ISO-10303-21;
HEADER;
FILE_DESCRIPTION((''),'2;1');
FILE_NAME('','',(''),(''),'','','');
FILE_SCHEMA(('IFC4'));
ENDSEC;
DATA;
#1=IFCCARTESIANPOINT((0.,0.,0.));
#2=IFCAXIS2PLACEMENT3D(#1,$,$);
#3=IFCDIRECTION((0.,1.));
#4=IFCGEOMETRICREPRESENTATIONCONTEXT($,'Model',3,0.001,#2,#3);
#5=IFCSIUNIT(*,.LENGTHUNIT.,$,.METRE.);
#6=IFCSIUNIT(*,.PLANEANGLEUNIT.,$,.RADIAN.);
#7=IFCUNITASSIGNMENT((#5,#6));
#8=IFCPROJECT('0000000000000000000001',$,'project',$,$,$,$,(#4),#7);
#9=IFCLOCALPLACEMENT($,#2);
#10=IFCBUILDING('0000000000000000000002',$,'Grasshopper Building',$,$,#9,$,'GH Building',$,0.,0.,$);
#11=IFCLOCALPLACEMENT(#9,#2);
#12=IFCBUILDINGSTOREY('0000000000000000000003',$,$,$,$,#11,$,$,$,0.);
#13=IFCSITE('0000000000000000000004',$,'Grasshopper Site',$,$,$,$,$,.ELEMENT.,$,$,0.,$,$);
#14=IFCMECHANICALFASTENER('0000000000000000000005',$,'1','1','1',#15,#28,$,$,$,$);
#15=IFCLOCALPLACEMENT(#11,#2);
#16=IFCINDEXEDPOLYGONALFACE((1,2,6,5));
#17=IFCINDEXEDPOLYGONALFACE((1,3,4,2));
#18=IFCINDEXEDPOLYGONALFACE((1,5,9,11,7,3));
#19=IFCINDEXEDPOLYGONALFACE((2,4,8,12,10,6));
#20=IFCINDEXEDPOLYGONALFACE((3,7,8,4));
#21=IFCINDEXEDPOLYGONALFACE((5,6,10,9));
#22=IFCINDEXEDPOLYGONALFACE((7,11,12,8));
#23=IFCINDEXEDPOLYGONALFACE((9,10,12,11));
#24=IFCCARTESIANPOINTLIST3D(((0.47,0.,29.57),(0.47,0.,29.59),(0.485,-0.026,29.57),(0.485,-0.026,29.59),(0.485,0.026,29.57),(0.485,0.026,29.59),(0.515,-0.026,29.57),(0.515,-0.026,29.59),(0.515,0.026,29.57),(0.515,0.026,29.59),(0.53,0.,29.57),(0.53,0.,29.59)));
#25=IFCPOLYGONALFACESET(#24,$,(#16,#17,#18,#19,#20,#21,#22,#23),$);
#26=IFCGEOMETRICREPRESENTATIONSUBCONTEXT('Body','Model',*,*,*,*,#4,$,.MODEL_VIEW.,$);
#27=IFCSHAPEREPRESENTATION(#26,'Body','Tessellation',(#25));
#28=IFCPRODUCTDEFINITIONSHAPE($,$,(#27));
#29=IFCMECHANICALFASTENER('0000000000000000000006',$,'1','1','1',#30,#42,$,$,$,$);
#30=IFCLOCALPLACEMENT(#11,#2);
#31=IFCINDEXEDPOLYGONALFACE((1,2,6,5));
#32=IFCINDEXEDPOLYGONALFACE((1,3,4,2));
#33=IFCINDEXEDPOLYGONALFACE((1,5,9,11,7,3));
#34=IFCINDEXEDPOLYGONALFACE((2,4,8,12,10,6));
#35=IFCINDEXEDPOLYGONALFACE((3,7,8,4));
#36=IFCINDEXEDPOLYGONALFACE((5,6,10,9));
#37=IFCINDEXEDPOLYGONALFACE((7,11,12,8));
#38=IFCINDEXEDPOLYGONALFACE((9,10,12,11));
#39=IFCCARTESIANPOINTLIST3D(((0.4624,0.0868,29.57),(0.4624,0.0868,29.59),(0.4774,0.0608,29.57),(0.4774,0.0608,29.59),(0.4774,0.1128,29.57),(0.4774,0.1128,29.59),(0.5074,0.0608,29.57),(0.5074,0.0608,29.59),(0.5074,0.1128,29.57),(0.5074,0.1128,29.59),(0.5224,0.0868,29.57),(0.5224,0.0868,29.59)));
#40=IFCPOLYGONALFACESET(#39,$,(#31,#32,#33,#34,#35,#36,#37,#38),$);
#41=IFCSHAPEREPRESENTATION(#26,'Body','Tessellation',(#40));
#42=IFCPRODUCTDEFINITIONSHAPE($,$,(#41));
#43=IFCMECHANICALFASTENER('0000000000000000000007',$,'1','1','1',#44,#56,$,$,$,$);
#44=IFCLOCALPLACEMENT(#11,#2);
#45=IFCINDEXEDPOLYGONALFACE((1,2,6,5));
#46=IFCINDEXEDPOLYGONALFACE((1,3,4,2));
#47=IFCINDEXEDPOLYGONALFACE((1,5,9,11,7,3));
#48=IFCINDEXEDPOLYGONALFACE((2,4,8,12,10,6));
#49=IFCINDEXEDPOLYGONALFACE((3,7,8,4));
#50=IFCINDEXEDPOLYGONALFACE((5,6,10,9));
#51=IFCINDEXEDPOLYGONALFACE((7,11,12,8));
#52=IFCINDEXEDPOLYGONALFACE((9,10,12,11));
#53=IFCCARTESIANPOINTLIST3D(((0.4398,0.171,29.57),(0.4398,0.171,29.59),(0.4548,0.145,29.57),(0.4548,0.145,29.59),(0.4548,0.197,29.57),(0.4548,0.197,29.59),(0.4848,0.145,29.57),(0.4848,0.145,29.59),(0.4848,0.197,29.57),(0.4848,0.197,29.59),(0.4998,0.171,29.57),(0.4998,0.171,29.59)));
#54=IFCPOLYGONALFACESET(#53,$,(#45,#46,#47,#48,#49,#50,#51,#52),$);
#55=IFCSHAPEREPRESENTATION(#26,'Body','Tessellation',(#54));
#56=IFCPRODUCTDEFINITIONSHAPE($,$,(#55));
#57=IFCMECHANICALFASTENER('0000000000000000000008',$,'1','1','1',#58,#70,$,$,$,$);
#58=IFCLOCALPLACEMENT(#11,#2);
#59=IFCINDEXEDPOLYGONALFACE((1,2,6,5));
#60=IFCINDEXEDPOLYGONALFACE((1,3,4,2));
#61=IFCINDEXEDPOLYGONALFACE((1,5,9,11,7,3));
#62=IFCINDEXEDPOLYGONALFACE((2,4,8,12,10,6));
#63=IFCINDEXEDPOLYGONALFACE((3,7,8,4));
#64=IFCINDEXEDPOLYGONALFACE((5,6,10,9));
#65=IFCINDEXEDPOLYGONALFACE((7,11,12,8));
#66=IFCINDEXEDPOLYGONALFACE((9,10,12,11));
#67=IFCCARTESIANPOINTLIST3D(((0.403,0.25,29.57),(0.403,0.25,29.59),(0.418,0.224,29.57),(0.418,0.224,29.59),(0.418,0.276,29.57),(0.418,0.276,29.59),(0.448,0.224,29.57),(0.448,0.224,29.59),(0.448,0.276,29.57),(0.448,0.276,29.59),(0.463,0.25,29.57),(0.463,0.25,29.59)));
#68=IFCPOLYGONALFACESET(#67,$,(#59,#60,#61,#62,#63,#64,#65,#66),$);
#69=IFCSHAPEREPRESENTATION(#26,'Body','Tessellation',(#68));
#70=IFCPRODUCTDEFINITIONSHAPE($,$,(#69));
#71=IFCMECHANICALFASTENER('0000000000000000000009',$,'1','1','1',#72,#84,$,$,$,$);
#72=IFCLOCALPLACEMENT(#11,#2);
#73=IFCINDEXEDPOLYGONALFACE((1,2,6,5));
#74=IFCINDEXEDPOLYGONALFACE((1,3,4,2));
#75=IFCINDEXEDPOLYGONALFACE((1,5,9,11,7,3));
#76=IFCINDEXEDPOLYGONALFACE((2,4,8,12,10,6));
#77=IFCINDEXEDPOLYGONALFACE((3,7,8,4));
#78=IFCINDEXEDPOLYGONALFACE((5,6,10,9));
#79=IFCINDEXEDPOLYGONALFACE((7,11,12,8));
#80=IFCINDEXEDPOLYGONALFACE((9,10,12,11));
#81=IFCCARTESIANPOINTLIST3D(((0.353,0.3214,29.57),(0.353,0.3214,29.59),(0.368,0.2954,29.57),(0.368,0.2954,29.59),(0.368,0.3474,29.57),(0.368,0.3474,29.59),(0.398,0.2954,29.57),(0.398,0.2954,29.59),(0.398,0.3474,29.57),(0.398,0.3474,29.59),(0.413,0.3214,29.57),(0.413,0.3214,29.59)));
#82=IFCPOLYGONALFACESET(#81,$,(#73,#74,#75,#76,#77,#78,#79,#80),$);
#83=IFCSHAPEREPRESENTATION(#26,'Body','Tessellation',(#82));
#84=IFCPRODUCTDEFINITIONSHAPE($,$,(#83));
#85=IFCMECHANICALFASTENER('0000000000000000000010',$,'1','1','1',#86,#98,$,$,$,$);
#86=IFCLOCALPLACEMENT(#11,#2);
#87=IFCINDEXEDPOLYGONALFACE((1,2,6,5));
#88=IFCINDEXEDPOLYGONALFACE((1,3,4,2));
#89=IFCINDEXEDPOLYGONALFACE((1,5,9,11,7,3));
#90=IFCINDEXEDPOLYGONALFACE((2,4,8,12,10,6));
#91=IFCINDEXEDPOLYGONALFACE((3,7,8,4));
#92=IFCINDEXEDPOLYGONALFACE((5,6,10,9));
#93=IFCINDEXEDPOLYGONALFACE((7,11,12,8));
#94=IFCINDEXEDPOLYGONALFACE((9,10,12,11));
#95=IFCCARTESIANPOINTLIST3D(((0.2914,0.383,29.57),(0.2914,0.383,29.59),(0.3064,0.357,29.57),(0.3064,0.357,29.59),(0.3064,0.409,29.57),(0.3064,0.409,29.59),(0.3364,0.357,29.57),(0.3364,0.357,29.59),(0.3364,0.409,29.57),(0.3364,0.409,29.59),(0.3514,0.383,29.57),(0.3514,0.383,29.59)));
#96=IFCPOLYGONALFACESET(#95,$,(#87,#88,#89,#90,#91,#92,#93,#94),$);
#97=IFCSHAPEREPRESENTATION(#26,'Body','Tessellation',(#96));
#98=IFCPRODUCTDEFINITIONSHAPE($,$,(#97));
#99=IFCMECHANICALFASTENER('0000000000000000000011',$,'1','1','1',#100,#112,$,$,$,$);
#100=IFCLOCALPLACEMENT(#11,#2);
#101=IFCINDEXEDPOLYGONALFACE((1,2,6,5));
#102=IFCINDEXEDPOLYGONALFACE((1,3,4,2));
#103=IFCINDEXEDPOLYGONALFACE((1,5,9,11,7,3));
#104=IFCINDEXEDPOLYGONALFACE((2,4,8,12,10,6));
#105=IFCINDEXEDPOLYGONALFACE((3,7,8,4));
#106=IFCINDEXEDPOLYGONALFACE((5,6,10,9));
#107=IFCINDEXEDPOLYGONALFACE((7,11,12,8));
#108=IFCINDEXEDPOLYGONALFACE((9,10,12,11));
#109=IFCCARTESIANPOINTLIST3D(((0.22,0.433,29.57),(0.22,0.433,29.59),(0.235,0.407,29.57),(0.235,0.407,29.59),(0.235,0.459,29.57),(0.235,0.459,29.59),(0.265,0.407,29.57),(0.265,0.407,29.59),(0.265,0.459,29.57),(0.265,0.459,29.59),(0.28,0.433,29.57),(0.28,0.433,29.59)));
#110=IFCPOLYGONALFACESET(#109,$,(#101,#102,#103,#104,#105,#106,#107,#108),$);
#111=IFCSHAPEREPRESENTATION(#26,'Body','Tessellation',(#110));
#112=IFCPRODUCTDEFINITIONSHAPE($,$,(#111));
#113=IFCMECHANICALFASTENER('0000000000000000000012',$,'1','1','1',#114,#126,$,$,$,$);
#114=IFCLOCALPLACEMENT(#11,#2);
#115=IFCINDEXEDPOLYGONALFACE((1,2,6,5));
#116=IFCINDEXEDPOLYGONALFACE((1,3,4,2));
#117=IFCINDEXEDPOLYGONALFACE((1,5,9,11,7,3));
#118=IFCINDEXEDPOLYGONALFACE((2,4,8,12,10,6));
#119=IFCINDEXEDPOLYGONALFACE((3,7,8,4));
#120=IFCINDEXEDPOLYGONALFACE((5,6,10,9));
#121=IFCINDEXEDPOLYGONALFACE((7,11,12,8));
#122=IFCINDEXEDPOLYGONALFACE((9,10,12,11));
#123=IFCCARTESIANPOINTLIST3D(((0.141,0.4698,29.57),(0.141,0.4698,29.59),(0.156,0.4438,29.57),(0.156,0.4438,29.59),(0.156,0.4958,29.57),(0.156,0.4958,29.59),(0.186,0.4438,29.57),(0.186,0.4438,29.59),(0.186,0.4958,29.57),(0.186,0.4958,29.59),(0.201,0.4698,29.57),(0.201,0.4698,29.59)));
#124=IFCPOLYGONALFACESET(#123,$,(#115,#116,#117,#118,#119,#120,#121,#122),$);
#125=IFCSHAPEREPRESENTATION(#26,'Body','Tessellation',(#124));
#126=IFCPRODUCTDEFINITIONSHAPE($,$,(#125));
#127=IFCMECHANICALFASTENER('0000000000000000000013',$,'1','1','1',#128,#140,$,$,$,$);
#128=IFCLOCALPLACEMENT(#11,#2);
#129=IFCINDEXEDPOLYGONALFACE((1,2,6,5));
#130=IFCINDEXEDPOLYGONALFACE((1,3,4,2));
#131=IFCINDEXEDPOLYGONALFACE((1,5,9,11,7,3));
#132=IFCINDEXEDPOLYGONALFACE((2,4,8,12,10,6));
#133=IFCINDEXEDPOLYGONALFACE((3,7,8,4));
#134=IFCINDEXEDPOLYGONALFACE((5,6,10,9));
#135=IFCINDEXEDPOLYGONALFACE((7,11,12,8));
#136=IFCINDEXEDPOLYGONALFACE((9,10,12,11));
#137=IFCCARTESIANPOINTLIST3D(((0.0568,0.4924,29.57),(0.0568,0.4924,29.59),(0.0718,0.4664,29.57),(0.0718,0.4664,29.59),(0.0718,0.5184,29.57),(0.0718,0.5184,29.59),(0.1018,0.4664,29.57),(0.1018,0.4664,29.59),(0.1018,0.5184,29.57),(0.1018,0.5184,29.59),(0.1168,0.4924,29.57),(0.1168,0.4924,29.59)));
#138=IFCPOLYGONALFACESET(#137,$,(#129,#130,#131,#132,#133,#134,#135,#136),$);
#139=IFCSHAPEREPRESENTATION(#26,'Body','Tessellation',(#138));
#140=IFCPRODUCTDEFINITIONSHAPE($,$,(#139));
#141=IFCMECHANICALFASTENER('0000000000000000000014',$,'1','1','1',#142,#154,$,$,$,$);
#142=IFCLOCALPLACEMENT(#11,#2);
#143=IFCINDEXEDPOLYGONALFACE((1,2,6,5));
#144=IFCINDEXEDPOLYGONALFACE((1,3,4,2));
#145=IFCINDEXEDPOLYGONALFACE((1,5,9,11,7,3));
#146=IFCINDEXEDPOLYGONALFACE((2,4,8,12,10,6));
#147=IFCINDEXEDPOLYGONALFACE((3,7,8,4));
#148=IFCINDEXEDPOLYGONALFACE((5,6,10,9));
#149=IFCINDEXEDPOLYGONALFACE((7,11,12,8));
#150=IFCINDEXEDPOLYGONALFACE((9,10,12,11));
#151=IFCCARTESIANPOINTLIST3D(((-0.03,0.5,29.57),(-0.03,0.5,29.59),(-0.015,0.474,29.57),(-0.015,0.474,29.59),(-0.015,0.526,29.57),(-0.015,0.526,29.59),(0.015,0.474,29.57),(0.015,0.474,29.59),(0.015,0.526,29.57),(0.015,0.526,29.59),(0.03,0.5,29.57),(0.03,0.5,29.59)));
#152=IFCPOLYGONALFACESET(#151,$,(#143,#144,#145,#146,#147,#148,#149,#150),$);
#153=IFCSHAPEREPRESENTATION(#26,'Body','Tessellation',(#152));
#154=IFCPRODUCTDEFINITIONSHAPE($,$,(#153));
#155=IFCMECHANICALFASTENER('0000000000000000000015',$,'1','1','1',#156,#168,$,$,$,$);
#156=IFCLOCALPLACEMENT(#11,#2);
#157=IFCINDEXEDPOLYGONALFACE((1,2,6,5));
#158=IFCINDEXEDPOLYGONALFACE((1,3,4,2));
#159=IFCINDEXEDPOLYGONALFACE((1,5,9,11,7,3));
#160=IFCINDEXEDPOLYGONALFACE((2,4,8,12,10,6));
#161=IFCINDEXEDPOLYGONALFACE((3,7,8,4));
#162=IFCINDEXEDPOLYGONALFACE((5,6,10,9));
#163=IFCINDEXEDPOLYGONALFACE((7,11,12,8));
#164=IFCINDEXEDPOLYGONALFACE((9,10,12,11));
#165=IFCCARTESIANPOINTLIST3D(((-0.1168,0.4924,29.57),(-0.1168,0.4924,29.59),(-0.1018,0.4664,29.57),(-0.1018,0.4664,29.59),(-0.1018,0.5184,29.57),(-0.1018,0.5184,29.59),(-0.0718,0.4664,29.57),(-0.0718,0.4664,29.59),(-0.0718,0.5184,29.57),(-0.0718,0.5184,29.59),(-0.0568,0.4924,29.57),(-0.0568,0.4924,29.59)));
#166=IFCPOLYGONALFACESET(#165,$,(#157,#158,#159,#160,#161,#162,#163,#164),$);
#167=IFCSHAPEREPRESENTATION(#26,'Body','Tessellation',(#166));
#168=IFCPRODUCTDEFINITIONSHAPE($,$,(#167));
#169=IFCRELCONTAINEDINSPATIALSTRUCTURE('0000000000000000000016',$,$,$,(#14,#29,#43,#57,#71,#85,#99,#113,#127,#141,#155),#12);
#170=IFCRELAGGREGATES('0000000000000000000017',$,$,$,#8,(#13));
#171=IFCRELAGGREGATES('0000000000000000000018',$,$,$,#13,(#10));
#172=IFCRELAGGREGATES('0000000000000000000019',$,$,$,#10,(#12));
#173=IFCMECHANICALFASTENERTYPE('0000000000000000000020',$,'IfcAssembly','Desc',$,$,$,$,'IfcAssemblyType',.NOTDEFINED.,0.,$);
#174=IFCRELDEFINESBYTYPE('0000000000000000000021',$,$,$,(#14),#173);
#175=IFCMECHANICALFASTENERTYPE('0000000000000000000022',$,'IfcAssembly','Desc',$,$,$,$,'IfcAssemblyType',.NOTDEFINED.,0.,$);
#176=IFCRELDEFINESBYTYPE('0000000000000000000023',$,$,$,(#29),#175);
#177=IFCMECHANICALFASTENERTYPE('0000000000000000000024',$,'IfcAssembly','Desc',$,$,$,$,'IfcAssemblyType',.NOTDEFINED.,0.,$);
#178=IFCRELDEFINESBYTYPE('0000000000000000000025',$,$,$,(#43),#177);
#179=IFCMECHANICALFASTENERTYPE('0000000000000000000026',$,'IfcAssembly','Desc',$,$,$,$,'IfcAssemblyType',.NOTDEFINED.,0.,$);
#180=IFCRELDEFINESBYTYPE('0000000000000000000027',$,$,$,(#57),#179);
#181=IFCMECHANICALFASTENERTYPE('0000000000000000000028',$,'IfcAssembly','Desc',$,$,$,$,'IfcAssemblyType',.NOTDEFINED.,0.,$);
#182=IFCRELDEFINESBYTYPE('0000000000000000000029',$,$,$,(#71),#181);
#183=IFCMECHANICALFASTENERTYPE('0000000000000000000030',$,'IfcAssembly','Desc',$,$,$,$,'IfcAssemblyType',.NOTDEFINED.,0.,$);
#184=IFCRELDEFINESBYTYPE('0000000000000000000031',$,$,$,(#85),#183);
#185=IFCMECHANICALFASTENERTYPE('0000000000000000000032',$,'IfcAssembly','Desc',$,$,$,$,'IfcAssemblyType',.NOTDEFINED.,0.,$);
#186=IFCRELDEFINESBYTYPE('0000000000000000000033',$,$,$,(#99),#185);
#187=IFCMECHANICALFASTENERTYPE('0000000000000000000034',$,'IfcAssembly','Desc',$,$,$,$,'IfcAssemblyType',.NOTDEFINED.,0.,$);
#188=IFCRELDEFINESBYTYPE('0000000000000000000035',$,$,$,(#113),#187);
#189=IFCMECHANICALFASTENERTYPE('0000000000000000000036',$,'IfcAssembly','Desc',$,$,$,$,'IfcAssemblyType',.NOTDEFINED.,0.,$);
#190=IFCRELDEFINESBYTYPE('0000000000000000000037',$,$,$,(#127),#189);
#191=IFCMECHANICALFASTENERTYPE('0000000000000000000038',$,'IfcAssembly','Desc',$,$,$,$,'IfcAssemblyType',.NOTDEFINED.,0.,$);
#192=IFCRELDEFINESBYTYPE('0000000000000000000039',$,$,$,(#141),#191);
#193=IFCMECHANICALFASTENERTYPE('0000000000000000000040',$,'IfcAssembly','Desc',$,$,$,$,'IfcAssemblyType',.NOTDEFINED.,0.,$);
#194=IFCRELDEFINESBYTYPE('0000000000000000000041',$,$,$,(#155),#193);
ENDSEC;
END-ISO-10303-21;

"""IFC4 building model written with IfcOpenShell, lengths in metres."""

from ifc_helpers import new_model, si_unit, direction, frame, origin, place, context, subcontext, project, spatial, indexed_curve, outline, extrude, source, transform, mapped, type_object, type_shapes, element, save


model = new_model("IFC4")

# Units and contexts
model_context = context("Model", 3, precision=0.001, world=origin(), true_north=direction((0.0, 1.0)))
body_context = subcontext(model_context, "Body", "Model", "MODEL_VIEW")
ifc_project = project(units=[si_unit("LENGTHUNIT", "METRE"), si_unit("PLANEANGLEUNIT", "RADIAN")], contexts=[model_context])

# Site, building, storey
site = spatial("IfcSite", under=ifc_project, Name="Grasshopper Site", CompositionType="ELEMENT", RefElevation=0.0)
building_placement = place(None, origin())
building = spatial("IfcBuilding", under=site, at=building_placement, Name="Grasshopper Building", LongName="GH Building", ElevationOfRefHeight=0.0, ElevationOfTerrain=0.0)
storey_placement = place(building_placement, origin())
storey = spatial("IfcBuildingStorey", under=building, at=storey_placement, Elevation=0.0)

# Mechanical fasteners
mechanical_fastener_type_1 = type_object("IfcMechanicalFastenerType", Name="IfcAssembly", Description="Desc", ElementType="IfcAssemblyType", NominalDiameter=0.0)
shared_shape_1 = source(origin(), body_context, "Body", "SweptSolid", [
    extrude(outline(indexed_curve([(0.03, 0.0), (0.015, 0.026), (-0.015, 0.026), (-0.03, 0.0), (-0.015, -0.026), (0.015, -0.026), (0.03, 0.0)])), frame((0.5, 0.0, 29.57)), (0.0, 0.0, 1.0), 0.02),
])
type_shapes(mechanical_fastener_type_1, [shared_shape_1])
mechanical_fastener_1_placement = place(storey_placement, origin())
element("IfcMechanicalFastener", 1, at=mechanical_fastener_1_placement, inside=storey, type_object=mechanical_fastener_type_1, Name="1", Description="1", ObjectType="1", context=body_context, shape_type="MappedRepresentation", body=[
    mapped(shared_shape_1, transform((0.0, 0.0, 0.0), scale=1.0)),
])
mechanical_fastener_type_2 = type_object("IfcMechanicalFastenerType", Name="IfcAssembly", Description="Desc", ElementType="IfcAssemblyType", NominalDiameter=0.0)
shared_shape_2 = source(origin(), body_context, "Body", "SweptSolid", [
    extrude(outline(indexed_curve([(0.03, 0.0), (0.015, 0.026), (-0.015, 0.026), (-0.03, 0.0), (-0.015, -0.026), (0.015, -0.026), (0.03, 0.0)])), frame((0.4924, 0.0868, 29.57)), (0.0, 0.0, 1.0), 0.02),
])
type_shapes(mechanical_fastener_type_2, [shared_shape_2])
mechanical_fastener_2_placement = place(storey_placement, origin())
element("IfcMechanicalFastener", 2, at=mechanical_fastener_2_placement, inside=storey, type_object=mechanical_fastener_type_2, Name="1", Description="1", ObjectType="1", context=body_context, shape_type="MappedRepresentation", body=[
    mapped(shared_shape_2, transform((0.0, 0.0, 0.0), scale=1.0)),
])
mechanical_fastener_type_3 = type_object("IfcMechanicalFastenerType", Name="IfcAssembly", Description="Desc", ElementType="IfcAssemblyType", NominalDiameter=0.0)
shared_shape_3 = source(origin(), body_context, "Body", "SweptSolid", [
    extrude(outline(indexed_curve([(0.03, 0.0), (0.015, 0.026), (-0.015, 0.026), (-0.03, 0.0), (-0.015, -0.026), (0.015, -0.026), (0.03, 0.0)])), frame((0.4698, 0.171, 29.57)), (0.0, 0.0, 1.0), 0.02),
])
type_shapes(mechanical_fastener_type_3, [shared_shape_3])
mechanical_fastener_3_placement = place(storey_placement, origin())
element("IfcMechanicalFastener", 3, at=mechanical_fastener_3_placement, inside=storey, type_object=mechanical_fastener_type_3, Name="1", Description="1", ObjectType="1", context=body_context, shape_type="MappedRepresentation", body=[
    mapped(shared_shape_3, transform((0.0, 0.0, 0.0), scale=1.0)),
])
mechanical_fastener_type_4 = type_object("IfcMechanicalFastenerType", Name="IfcAssembly", Description="Desc", ElementType="IfcAssemblyType", NominalDiameter=0.0)
shared_shape_4 = source(origin(), body_context, "Body", "SweptSolid", [
    extrude(outline(indexed_curve([(0.03, 0.0), (0.015, 0.026), (-0.015, 0.026), (-0.03, 0.0), (-0.015, -0.026), (0.015, -0.026), (0.03, 0.0)])), frame((0.433, 0.25, 29.57)), (0.0, 0.0, 1.0), 0.02),
])
type_shapes(mechanical_fastener_type_4, [shared_shape_4])
mechanical_fastener_4_placement = place(storey_placement, origin())
element("IfcMechanicalFastener", 4, at=mechanical_fastener_4_placement, inside=storey, type_object=mechanical_fastener_type_4, Name="1", Description="1", ObjectType="1", context=body_context, shape_type="MappedRepresentation", body=[
    mapped(shared_shape_4, transform((0.0, 0.0, 0.0), scale=1.0)),
])
mechanical_fastener_type_5 = type_object("IfcMechanicalFastenerType", Name="IfcAssembly", Description="Desc", ElementType="IfcAssemblyType", NominalDiameter=0.0)
shared_shape_5 = source(origin(), body_context, "Body", "SweptSolid", [
    extrude(outline(indexed_curve([(0.03, 0.0), (0.015, 0.026), (-0.015, 0.026), (-0.03, 0.0), (-0.015, -0.026), (0.015, -0.026), (0.03, 0.0)])), frame((0.383, 0.3214, 29.57)), (0.0, 0.0, 1.0), 0.02),
])
type_shapes(mechanical_fastener_type_5, [shared_shape_5])
mechanical_fastener_5_placement = place(storey_placement, origin())
element("IfcMechanicalFastener", 5, at=mechanical_fastener_5_placement, inside=storey, type_object=mechanical_fastener_type_5, Name="1", Description="1", ObjectType="1", context=body_context, shape_type="MappedRepresentation", body=[
    mapped(shared_shape_5, transform((0.0, 0.0, 0.0), scale=1.0)),
])
mechanical_fastener_type_6 = type_object("IfcMechanicalFastenerType", Name="IfcAssembly", Description="Desc", ElementType="IfcAssemblyType", NominalDiameter=0.0)
shared_shape_6 = source(origin(), body_context, "Body", "SweptSolid", [
    extrude(outline(indexed_curve([(0.03, 0.0), (0.015, 0.026), (-0.015, 0.026), (-0.03, 0.0), (-0.015, -0.026), (0.015, -0.026), (0.03, 0.0)])), frame((0.3214, 0.383, 29.57)), (0.0, 0.0, 1.0), 0.02),
])
type_shapes(mechanical_fastener_type_6, [shared_shape_6])
mechanical_fastener_6_placement = place(storey_placement, origin())
element("IfcMechanicalFastener", 6, at=mechanical_fastener_6_placement, inside=storey, type_object=mechanical_fastener_type_6, Name="1", Description="1", ObjectType="1", context=body_context, shape_type="MappedRepresentation", body=[
    mapped(shared_shape_6, transform((0.0, 0.0, 0.0), scale=1.0)),
])
mechanical_fastener_type_7 = type_object("IfcMechanicalFastenerType", Name="IfcAssembly", Description="Desc", ElementType="IfcAssemblyType", NominalDiameter=0.0)
shared_shape_7 = source(origin(), body_context, "Body", "SweptSolid", [
    extrude(outline(indexed_curve([(0.03, 0.0), (0.015, 0.026), (-0.015, 0.026), (-0.03, 0.0), (-0.015, -0.026), (0.015, -0.026), (0.03, 0.0)])), frame((0.25, 0.433, 29.57)), (0.0, 0.0, 1.0), 0.02),
])
type_shapes(mechanical_fastener_type_7, [shared_shape_7])
mechanical_fastener_7_placement = place(storey_placement, origin())
element("IfcMechanicalFastener", 7, at=mechanical_fastener_7_placement, inside=storey, type_object=mechanical_fastener_type_7, Name="1", Description="1", ObjectType="1", context=body_context, shape_type="MappedRepresentation", body=[
    mapped(shared_shape_7, transform((0.0, 0.0, 0.0), scale=1.0)),
])
mechanical_fastener_type_8 = type_object("IfcMechanicalFastenerType", Name="IfcAssembly", Description="Desc", ElementType="IfcAssemblyType", NominalDiameter=0.0)
shared_shape_8 = source(origin(), body_context, "Body", "SweptSolid", [
    extrude(outline(indexed_curve([(0.03, 0.0), (0.015, 0.026), (-0.015, 0.026), (-0.03, 0.0), (-0.015, -0.026), (0.015, -0.026), (0.03, 0.0)])), frame((0.171, 0.4698, 29.57)), (0.0, 0.0, 1.0), 0.02),
])
type_shapes(mechanical_fastener_type_8, [shared_shape_8])
mechanical_fastener_8_placement = place(storey_placement, origin())
element("IfcMechanicalFastener", 8, at=mechanical_fastener_8_placement, inside=storey, type_object=mechanical_fastener_type_8, Name="1", Description="1", ObjectType="1", context=body_context, shape_type="MappedRepresentation", body=[
    mapped(shared_shape_8, transform((0.0, 0.0, 0.0), scale=1.0)),
])
mechanical_fastener_type_9 = type_object("IfcMechanicalFastenerType", Name="IfcAssembly", Description="Desc", ElementType="IfcAssemblyType", NominalDiameter=0.0)
shared_shape_9 = source(origin(), body_context, "Body", "SweptSolid", [
    extrude(outline(indexed_curve([(0.03, 0.0), (0.015, 0.026), (-0.015, 0.026), (-0.03, 0.0), (-0.015, -0.026), (0.015, -0.026), (0.03, 0.0)])), frame((0.0868, 0.4924, 29.57)), (0.0, 0.0, 1.0), 0.02),
])
type_shapes(mechanical_fastener_type_9, [shared_shape_9])
mechanical_fastener_9_placement = place(storey_placement, origin())
element("IfcMechanicalFastener", 9, at=mechanical_fastener_9_placement, inside=storey, type_object=mechanical_fastener_type_9, Name="1", Description="1", ObjectType="1", context=body_context, shape_type="MappedRepresentation", body=[
    mapped(shared_shape_9, transform((0.0, 0.0, 0.0), scale=1.0)),
])
mechanical_fastener_type_10 = type_object("IfcMechanicalFastenerType", Name="IfcAssembly", Description="Desc", ElementType="IfcAssemblyType", NominalDiameter=0.0)
shared_shape_10 = source(origin(), body_context, "Body", "SweptSolid", [
    extrude(outline(indexed_curve([(0.03, 0.0), (0.015, 0.026), (-0.015, 0.026), (-0.03, 0.0), (-0.015, -0.026), (0.015, -0.026), (0.03, 0.0)])), frame((0.0, 0.5, 29.57)), (0.0, 0.0, 1.0), 0.02),
])
type_shapes(mechanical_fastener_type_10, [shared_shape_10])
mechanical_fastener_10_placement = place(storey_placement, origin())
element("IfcMechanicalFastener", 10, at=mechanical_fastener_10_placement, inside=storey, type_object=mechanical_fastener_type_10, Name="1", Description="1", ObjectType="1", context=body_context, shape_type="MappedRepresentation", body=[
    mapped(shared_shape_10, transform((0.0, 0.0, 0.0), scale=1.0)),
])
mechanical_fastener_type_11 = type_object("IfcMechanicalFastenerType", Name="IfcAssembly", Description="Desc", ElementType="IfcAssemblyType", NominalDiameter=0.0)
shared_shape_11 = source(origin(), body_context, "Body", "SweptSolid", [
    extrude(outline(indexed_curve([(0.03, 0.0), (0.015, 0.026), (-0.015, 0.026), (-0.03, 0.0), (-0.015, -0.026), (0.015, -0.026), (0.03, 0.0)])), frame((-0.0868, 0.4924, 29.57)), (0.0, 0.0, 1.0), 0.02),
])
type_shapes(mechanical_fastener_type_11, [shared_shape_11])
mechanical_fastener_11_placement = place(storey_placement, origin())
element("IfcMechanicalFastener", 11, at=mechanical_fastener_11_placement, inside=storey, type_object=mechanical_fastener_type_11, Name="1", Description="1", ObjectType="1", context=body_context, shape_type="MappedRepresentation", body=[
    mapped(shared_shape_11, transform((0.0, 0.0, 0.0), scale=1.0)),
])

save(model, "model.ifc")
